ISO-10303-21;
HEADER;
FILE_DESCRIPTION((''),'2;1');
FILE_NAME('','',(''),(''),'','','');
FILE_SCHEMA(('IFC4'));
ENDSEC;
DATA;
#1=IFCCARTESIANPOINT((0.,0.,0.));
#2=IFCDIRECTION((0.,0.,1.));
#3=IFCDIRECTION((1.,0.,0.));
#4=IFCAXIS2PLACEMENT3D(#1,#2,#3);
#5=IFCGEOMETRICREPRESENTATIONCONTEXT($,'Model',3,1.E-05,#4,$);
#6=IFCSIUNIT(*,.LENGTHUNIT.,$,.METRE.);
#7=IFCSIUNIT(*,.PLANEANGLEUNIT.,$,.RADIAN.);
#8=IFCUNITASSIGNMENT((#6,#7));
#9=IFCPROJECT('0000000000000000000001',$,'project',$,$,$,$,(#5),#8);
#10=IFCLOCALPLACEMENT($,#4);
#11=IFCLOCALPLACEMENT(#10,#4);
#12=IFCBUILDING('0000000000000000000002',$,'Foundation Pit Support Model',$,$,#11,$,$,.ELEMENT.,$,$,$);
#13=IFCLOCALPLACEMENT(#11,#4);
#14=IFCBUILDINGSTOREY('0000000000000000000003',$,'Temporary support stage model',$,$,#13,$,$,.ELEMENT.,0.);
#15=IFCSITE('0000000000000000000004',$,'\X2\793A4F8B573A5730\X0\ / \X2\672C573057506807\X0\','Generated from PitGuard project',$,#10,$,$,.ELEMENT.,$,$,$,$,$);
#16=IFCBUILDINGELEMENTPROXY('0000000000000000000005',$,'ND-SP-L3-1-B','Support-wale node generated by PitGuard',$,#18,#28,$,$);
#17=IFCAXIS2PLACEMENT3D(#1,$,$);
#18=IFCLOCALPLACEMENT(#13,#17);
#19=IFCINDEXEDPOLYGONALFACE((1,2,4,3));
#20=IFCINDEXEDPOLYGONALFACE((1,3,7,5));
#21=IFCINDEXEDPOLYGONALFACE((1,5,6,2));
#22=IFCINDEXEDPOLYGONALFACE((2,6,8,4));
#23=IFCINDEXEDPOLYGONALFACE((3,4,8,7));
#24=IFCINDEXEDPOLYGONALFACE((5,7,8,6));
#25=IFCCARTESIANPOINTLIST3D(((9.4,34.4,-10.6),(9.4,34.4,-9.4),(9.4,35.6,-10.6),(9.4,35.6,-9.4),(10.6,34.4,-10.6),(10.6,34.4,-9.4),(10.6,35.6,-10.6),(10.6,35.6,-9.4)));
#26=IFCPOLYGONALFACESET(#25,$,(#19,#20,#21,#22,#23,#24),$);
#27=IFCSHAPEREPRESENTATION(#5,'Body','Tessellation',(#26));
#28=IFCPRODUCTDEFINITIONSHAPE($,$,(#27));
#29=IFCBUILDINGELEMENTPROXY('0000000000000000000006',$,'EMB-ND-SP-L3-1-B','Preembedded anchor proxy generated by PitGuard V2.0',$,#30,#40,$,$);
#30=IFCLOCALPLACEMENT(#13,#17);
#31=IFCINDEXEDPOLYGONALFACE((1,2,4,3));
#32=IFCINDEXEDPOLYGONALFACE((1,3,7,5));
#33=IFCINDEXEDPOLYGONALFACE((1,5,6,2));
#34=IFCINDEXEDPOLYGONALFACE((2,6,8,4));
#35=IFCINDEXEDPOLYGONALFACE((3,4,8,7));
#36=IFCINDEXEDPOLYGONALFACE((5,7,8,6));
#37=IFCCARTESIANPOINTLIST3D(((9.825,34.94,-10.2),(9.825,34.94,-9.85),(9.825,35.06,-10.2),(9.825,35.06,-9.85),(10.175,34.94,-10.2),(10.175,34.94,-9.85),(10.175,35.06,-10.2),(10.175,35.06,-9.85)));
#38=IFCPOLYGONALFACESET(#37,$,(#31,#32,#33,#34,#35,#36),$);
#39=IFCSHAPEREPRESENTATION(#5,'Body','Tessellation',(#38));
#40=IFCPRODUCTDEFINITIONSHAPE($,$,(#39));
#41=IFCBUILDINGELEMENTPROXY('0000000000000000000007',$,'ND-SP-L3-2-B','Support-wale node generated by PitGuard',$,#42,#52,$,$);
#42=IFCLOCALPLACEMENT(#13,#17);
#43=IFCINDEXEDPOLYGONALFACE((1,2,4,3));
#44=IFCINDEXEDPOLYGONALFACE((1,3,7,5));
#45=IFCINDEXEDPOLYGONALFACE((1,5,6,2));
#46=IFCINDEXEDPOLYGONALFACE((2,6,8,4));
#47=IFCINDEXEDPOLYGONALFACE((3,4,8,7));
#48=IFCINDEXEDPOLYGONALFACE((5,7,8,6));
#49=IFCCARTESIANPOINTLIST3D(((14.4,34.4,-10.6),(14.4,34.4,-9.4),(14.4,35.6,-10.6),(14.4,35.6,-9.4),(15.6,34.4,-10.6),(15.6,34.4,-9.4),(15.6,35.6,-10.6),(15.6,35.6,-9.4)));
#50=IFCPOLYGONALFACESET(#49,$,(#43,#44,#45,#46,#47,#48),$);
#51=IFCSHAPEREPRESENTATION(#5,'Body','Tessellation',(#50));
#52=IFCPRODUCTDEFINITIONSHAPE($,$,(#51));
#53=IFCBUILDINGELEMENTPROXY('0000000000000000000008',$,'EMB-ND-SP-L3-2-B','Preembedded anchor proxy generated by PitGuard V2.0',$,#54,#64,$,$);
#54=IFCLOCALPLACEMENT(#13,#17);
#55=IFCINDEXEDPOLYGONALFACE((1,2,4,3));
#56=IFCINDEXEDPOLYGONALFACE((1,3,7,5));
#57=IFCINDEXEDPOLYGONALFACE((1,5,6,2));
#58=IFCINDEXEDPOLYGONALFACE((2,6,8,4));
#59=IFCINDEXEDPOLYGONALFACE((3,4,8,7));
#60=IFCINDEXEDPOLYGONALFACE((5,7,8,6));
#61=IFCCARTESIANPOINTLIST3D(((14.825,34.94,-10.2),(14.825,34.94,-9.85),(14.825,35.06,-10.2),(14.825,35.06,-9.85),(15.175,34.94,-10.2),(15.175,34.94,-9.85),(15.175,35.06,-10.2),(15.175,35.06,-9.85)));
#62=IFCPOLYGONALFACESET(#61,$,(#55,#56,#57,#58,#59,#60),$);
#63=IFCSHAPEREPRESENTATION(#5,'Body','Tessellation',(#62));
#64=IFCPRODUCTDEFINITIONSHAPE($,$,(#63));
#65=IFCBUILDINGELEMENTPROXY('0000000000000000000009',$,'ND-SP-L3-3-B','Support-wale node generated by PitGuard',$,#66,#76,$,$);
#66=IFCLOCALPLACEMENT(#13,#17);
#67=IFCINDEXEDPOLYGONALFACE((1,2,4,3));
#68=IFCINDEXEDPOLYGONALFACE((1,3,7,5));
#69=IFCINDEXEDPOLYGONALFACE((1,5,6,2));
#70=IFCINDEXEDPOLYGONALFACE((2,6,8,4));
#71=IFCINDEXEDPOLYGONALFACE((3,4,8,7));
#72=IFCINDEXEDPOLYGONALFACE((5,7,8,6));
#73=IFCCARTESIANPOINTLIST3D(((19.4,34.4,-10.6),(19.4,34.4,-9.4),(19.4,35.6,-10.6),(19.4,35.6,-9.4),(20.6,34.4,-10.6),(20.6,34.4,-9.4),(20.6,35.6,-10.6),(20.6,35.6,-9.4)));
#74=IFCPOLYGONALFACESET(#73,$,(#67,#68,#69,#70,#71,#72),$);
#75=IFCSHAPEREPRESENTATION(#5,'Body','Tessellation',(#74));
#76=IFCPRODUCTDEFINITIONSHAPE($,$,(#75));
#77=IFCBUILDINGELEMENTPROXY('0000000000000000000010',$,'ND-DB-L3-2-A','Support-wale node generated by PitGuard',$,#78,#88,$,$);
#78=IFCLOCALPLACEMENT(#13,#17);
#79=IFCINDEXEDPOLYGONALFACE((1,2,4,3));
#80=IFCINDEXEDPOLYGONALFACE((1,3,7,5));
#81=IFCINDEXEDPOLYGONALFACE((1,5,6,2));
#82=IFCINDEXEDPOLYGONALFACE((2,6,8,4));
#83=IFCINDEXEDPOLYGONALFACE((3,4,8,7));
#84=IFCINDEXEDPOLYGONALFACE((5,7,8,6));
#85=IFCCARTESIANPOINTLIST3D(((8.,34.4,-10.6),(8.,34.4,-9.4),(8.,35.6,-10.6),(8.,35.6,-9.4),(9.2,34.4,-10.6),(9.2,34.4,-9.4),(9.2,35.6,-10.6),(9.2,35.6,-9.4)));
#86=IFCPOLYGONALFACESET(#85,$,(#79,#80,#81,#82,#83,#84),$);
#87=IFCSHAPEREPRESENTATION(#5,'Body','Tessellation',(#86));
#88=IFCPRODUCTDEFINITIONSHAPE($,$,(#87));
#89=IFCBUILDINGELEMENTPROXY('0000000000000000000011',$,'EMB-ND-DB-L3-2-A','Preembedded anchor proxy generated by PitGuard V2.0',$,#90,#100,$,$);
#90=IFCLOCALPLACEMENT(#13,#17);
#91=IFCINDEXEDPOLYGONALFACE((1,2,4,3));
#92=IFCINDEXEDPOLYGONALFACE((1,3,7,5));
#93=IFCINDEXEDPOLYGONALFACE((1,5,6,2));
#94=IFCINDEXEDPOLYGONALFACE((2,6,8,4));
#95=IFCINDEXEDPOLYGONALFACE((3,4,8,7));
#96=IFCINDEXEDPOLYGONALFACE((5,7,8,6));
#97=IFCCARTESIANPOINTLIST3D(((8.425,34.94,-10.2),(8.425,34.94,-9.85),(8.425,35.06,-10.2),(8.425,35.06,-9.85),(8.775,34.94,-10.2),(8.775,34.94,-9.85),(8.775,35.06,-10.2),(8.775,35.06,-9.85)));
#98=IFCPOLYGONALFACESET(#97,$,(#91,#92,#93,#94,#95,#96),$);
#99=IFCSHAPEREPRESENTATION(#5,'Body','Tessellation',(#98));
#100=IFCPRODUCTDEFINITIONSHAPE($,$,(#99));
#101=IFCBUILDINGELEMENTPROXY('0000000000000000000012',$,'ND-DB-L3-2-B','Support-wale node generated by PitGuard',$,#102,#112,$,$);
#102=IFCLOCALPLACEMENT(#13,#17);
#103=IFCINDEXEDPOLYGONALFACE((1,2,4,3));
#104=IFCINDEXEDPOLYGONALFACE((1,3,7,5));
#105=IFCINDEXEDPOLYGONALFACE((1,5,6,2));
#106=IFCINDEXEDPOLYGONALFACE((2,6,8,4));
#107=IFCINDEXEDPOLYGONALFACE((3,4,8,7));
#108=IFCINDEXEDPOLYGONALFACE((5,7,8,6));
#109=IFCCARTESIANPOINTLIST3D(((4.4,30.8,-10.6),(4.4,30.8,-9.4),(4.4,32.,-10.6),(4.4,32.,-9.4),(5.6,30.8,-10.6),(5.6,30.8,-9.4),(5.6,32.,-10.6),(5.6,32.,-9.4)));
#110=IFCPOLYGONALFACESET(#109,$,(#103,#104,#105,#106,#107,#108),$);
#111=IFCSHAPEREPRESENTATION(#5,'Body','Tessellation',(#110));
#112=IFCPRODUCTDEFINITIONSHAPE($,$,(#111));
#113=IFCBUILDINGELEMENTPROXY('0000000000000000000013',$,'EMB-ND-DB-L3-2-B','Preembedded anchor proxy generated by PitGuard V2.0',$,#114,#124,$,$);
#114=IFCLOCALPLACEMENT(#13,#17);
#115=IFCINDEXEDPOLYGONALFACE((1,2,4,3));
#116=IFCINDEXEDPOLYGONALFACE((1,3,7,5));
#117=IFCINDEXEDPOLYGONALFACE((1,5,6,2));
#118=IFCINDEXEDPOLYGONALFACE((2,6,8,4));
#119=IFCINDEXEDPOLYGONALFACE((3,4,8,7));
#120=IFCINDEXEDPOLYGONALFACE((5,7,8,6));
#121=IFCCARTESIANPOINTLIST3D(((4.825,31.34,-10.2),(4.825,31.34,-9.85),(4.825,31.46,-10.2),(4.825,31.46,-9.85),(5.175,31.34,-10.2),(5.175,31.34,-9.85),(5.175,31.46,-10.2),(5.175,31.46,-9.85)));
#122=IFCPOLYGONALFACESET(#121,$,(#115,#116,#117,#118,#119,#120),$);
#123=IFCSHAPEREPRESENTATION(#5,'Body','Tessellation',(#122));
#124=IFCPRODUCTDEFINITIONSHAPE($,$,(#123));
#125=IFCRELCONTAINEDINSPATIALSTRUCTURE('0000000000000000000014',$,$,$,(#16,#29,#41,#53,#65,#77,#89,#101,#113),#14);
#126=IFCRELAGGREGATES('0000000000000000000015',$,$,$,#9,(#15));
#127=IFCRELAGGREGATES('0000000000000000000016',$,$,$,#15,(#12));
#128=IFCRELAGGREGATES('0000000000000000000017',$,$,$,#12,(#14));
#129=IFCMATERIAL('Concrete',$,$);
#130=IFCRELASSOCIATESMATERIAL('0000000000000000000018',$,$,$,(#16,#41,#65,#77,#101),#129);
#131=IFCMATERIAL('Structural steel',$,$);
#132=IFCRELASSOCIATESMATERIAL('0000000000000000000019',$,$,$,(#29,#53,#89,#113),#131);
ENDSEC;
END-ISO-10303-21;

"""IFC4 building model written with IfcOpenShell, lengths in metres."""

from ifc_helpers import new_model, si_unit, frame, origin_with_axes, origin_2d, place, context, project, spatial, rectangle, extrude, material, element, save


model = new_model("IFC4")

# Units and contexts
model_context = context("Model", 3, precision=1e-05, world=origin_with_axes())
ifc_project = project(units=[si_unit("LENGTHUNIT", "METRE"), si_unit("PLANEANGLEUNIT", "RADIAN")], contexts=[model_context])

# Site, building, storey
site_placement = place(None, origin_with_axes())
site = spatial("IfcSite", under=ifc_project, at=site_placement, Name="示例场地 / 本地坐标", Description="Generated from PitGuard project", CompositionType="ELEMENT")
building_placement = place(site_placement, origin_with_axes())
building = spatial("IfcBuilding", under=site, at=building_placement, Name="Foundation Pit Support Model", CompositionType="ELEMENT")
storey_placement = place(building_placement, origin_with_axes())
storey = spatial("IfcBuildingStorey", under=building, at=storey_placement, Name="Temporary support stage model", CompositionType="ELEMENT", Elevation=0.0)

# Shared definitions
ifc_material_1 = material(Name="Structural steel")

# Shared definitions
ifc_material_2 = material(Name="Concrete")

# Building element proxies
proxy_1_placement = place(storey_placement, frame((10.0, 35.0, -10.6), z_axis=(0.0, 0.0, 1.0), x_axis=(1.0, 0.0, 0.0)))
element("IfcBuildingElementProxy", 1, at=proxy_1_placement, inside=storey, material=ifc_material_2, Name="ND-SP-L3-1-B", Description="Support-wale node generated by PitGuard", context=model_context, shape_type="SweptSolid", body=[
    extrude(rectangle(XDim=1.2, YDim=1.2, at=origin_2d()), origin_with_axes(), (0.0, 0.0, 1.0), 1.2),
])
proxy_2_placement = place(storey_placement, frame((10.0, 35.0, -10.2), z_axis=(0.0, 0.0, 1.0), x_axis=(1.0, 0.0, 0.0)))
element("IfcBuildingElementProxy", 2, at=proxy_2_placement, inside=storey, material=ifc_material_1, Name="EMB-ND-SP-L3-1-B", Description="Preembedded anchor proxy generated by PitGuard V2.0", context=model_context, shape_type="SweptSolid", body=[
    extrude(rectangle(XDim=0.35, YDim=0.12, at=origin_2d()), origin_with_axes(), (0.0, 0.0, 1.0), 0.35),
])
proxy_3_placement = place(storey_placement, frame((15.0, 35.0, -10.6), z_axis=(0.0, 0.0, 1.0), x_axis=(1.0, 0.0, 0.0)))
element("IfcBuildingElementProxy", 3, at=proxy_3_placement, inside=storey, material=ifc_material_2, Name="ND-SP-L3-2-B", Description="Support-wale node generated by PitGuard", context=model_context, shape_type="SweptSolid", body=[
    extrude(rectangle(XDim=1.2, YDim=1.2, at=origin_2d()), origin_with_axes(), (0.0, 0.0, 1.0), 1.2),
])
proxy_4_placement = place(storey_placement, frame((15.0, 35.0, -10.2), z_axis=(0.0, 0.0, 1.0), x_axis=(1.0, 0.0, 0.0)))
element("IfcBuildingElementProxy", 4, at=proxy_4_placement, inside=storey, material=ifc_material_1, Name="EMB-ND-SP-L3-2-B", Description="Preembedded anchor proxy generated by PitGuard V2.0", context=model_context, shape_type="SweptSolid", body=[
    extrude(rectangle(XDim=0.35, YDim=0.12, at=origin_2d()), origin_with_axes(), (0.0, 0.0, 1.0), 0.35),
])
for number, where, z_axis, x_axis, name in (
    (5, (20.0, 35.0, -10.6), (0.0, 0.0, 1.0), (1.0, 0.0, 0.0), "ND-SP-L3-3-B"),
    (6, (8.6, 35.0, -10.6), (0.0, 0.0, 1.0), (1.0, 0.0, 0.0), "ND-DB-L3-2-A"),
):
    element("IfcBuildingElementProxy", number, at=place(storey_placement, frame(where, z_axis=z_axis, x_axis=x_axis)), inside=storey, material=ifc_material_2, Name=name, Description="Support-wale node generated by PitGuard", context=model_context, shape_type="SweptSolid", body=[
        extrude(rectangle(XDim=1.2, YDim=1.2, at=origin_2d()), origin_with_axes(), (0.0, 0.0, 1.0), 1.2),
    ])
proxy_5_placement = place(storey_placement, frame((8.6, 35.0, -10.2), z_axis=(0.0, 0.0, 1.0), x_axis=(1.0, 0.0, 0.0)))
element("IfcBuildingElementProxy", 7, at=proxy_5_placement, inside=storey, material=ifc_material_1, Name="EMB-ND-DB-L3-2-A", Description="Preembedded anchor proxy generated by PitGuard V2.0", context=model_context, shape_type="SweptSolid", body=[
    extrude(rectangle(XDim=0.35, YDim=0.12, at=origin_2d()), origin_with_axes(), (0.0, 0.0, 1.0), 0.35),
])
proxy_6_placement = place(storey_placement, frame((5.0, 31.4, -10.6), z_axis=(0.0, 0.0, 1.0), x_axis=(1.0, 0.0, 0.0)))
element("IfcBuildingElementProxy", 8, at=proxy_6_placement, inside=storey, material=ifc_material_2, Name="ND-DB-L3-2-B", Description="Support-wale node generated by PitGuard", context=model_context, shape_type="SweptSolid", body=[
    extrude(rectangle(XDim=1.2, YDim=1.2, at=origin_2d()), origin_with_axes(), (0.0, 0.0, 1.0), 1.2),
])
proxy_7_placement = place(storey_placement, frame((5.0, 31.4, -10.2), z_axis=(0.0, 0.0, 1.0), x_axis=(1.0, 0.0, 0.0)))
element("IfcBuildingElementProxy", 9, at=proxy_7_placement, inside=storey, material=ifc_material_1, Name="EMB-ND-DB-L3-2-B", Description="Preembedded anchor proxy generated by PitGuard V2.0", context=model_context, shape_type="SweptSolid", body=[
    extrude(rectangle(XDim=0.35, YDim=0.12, at=origin_2d()), origin_with_axes(), (0.0, 0.0, 1.0), 0.35),
])

save(model, "model.ifc")
